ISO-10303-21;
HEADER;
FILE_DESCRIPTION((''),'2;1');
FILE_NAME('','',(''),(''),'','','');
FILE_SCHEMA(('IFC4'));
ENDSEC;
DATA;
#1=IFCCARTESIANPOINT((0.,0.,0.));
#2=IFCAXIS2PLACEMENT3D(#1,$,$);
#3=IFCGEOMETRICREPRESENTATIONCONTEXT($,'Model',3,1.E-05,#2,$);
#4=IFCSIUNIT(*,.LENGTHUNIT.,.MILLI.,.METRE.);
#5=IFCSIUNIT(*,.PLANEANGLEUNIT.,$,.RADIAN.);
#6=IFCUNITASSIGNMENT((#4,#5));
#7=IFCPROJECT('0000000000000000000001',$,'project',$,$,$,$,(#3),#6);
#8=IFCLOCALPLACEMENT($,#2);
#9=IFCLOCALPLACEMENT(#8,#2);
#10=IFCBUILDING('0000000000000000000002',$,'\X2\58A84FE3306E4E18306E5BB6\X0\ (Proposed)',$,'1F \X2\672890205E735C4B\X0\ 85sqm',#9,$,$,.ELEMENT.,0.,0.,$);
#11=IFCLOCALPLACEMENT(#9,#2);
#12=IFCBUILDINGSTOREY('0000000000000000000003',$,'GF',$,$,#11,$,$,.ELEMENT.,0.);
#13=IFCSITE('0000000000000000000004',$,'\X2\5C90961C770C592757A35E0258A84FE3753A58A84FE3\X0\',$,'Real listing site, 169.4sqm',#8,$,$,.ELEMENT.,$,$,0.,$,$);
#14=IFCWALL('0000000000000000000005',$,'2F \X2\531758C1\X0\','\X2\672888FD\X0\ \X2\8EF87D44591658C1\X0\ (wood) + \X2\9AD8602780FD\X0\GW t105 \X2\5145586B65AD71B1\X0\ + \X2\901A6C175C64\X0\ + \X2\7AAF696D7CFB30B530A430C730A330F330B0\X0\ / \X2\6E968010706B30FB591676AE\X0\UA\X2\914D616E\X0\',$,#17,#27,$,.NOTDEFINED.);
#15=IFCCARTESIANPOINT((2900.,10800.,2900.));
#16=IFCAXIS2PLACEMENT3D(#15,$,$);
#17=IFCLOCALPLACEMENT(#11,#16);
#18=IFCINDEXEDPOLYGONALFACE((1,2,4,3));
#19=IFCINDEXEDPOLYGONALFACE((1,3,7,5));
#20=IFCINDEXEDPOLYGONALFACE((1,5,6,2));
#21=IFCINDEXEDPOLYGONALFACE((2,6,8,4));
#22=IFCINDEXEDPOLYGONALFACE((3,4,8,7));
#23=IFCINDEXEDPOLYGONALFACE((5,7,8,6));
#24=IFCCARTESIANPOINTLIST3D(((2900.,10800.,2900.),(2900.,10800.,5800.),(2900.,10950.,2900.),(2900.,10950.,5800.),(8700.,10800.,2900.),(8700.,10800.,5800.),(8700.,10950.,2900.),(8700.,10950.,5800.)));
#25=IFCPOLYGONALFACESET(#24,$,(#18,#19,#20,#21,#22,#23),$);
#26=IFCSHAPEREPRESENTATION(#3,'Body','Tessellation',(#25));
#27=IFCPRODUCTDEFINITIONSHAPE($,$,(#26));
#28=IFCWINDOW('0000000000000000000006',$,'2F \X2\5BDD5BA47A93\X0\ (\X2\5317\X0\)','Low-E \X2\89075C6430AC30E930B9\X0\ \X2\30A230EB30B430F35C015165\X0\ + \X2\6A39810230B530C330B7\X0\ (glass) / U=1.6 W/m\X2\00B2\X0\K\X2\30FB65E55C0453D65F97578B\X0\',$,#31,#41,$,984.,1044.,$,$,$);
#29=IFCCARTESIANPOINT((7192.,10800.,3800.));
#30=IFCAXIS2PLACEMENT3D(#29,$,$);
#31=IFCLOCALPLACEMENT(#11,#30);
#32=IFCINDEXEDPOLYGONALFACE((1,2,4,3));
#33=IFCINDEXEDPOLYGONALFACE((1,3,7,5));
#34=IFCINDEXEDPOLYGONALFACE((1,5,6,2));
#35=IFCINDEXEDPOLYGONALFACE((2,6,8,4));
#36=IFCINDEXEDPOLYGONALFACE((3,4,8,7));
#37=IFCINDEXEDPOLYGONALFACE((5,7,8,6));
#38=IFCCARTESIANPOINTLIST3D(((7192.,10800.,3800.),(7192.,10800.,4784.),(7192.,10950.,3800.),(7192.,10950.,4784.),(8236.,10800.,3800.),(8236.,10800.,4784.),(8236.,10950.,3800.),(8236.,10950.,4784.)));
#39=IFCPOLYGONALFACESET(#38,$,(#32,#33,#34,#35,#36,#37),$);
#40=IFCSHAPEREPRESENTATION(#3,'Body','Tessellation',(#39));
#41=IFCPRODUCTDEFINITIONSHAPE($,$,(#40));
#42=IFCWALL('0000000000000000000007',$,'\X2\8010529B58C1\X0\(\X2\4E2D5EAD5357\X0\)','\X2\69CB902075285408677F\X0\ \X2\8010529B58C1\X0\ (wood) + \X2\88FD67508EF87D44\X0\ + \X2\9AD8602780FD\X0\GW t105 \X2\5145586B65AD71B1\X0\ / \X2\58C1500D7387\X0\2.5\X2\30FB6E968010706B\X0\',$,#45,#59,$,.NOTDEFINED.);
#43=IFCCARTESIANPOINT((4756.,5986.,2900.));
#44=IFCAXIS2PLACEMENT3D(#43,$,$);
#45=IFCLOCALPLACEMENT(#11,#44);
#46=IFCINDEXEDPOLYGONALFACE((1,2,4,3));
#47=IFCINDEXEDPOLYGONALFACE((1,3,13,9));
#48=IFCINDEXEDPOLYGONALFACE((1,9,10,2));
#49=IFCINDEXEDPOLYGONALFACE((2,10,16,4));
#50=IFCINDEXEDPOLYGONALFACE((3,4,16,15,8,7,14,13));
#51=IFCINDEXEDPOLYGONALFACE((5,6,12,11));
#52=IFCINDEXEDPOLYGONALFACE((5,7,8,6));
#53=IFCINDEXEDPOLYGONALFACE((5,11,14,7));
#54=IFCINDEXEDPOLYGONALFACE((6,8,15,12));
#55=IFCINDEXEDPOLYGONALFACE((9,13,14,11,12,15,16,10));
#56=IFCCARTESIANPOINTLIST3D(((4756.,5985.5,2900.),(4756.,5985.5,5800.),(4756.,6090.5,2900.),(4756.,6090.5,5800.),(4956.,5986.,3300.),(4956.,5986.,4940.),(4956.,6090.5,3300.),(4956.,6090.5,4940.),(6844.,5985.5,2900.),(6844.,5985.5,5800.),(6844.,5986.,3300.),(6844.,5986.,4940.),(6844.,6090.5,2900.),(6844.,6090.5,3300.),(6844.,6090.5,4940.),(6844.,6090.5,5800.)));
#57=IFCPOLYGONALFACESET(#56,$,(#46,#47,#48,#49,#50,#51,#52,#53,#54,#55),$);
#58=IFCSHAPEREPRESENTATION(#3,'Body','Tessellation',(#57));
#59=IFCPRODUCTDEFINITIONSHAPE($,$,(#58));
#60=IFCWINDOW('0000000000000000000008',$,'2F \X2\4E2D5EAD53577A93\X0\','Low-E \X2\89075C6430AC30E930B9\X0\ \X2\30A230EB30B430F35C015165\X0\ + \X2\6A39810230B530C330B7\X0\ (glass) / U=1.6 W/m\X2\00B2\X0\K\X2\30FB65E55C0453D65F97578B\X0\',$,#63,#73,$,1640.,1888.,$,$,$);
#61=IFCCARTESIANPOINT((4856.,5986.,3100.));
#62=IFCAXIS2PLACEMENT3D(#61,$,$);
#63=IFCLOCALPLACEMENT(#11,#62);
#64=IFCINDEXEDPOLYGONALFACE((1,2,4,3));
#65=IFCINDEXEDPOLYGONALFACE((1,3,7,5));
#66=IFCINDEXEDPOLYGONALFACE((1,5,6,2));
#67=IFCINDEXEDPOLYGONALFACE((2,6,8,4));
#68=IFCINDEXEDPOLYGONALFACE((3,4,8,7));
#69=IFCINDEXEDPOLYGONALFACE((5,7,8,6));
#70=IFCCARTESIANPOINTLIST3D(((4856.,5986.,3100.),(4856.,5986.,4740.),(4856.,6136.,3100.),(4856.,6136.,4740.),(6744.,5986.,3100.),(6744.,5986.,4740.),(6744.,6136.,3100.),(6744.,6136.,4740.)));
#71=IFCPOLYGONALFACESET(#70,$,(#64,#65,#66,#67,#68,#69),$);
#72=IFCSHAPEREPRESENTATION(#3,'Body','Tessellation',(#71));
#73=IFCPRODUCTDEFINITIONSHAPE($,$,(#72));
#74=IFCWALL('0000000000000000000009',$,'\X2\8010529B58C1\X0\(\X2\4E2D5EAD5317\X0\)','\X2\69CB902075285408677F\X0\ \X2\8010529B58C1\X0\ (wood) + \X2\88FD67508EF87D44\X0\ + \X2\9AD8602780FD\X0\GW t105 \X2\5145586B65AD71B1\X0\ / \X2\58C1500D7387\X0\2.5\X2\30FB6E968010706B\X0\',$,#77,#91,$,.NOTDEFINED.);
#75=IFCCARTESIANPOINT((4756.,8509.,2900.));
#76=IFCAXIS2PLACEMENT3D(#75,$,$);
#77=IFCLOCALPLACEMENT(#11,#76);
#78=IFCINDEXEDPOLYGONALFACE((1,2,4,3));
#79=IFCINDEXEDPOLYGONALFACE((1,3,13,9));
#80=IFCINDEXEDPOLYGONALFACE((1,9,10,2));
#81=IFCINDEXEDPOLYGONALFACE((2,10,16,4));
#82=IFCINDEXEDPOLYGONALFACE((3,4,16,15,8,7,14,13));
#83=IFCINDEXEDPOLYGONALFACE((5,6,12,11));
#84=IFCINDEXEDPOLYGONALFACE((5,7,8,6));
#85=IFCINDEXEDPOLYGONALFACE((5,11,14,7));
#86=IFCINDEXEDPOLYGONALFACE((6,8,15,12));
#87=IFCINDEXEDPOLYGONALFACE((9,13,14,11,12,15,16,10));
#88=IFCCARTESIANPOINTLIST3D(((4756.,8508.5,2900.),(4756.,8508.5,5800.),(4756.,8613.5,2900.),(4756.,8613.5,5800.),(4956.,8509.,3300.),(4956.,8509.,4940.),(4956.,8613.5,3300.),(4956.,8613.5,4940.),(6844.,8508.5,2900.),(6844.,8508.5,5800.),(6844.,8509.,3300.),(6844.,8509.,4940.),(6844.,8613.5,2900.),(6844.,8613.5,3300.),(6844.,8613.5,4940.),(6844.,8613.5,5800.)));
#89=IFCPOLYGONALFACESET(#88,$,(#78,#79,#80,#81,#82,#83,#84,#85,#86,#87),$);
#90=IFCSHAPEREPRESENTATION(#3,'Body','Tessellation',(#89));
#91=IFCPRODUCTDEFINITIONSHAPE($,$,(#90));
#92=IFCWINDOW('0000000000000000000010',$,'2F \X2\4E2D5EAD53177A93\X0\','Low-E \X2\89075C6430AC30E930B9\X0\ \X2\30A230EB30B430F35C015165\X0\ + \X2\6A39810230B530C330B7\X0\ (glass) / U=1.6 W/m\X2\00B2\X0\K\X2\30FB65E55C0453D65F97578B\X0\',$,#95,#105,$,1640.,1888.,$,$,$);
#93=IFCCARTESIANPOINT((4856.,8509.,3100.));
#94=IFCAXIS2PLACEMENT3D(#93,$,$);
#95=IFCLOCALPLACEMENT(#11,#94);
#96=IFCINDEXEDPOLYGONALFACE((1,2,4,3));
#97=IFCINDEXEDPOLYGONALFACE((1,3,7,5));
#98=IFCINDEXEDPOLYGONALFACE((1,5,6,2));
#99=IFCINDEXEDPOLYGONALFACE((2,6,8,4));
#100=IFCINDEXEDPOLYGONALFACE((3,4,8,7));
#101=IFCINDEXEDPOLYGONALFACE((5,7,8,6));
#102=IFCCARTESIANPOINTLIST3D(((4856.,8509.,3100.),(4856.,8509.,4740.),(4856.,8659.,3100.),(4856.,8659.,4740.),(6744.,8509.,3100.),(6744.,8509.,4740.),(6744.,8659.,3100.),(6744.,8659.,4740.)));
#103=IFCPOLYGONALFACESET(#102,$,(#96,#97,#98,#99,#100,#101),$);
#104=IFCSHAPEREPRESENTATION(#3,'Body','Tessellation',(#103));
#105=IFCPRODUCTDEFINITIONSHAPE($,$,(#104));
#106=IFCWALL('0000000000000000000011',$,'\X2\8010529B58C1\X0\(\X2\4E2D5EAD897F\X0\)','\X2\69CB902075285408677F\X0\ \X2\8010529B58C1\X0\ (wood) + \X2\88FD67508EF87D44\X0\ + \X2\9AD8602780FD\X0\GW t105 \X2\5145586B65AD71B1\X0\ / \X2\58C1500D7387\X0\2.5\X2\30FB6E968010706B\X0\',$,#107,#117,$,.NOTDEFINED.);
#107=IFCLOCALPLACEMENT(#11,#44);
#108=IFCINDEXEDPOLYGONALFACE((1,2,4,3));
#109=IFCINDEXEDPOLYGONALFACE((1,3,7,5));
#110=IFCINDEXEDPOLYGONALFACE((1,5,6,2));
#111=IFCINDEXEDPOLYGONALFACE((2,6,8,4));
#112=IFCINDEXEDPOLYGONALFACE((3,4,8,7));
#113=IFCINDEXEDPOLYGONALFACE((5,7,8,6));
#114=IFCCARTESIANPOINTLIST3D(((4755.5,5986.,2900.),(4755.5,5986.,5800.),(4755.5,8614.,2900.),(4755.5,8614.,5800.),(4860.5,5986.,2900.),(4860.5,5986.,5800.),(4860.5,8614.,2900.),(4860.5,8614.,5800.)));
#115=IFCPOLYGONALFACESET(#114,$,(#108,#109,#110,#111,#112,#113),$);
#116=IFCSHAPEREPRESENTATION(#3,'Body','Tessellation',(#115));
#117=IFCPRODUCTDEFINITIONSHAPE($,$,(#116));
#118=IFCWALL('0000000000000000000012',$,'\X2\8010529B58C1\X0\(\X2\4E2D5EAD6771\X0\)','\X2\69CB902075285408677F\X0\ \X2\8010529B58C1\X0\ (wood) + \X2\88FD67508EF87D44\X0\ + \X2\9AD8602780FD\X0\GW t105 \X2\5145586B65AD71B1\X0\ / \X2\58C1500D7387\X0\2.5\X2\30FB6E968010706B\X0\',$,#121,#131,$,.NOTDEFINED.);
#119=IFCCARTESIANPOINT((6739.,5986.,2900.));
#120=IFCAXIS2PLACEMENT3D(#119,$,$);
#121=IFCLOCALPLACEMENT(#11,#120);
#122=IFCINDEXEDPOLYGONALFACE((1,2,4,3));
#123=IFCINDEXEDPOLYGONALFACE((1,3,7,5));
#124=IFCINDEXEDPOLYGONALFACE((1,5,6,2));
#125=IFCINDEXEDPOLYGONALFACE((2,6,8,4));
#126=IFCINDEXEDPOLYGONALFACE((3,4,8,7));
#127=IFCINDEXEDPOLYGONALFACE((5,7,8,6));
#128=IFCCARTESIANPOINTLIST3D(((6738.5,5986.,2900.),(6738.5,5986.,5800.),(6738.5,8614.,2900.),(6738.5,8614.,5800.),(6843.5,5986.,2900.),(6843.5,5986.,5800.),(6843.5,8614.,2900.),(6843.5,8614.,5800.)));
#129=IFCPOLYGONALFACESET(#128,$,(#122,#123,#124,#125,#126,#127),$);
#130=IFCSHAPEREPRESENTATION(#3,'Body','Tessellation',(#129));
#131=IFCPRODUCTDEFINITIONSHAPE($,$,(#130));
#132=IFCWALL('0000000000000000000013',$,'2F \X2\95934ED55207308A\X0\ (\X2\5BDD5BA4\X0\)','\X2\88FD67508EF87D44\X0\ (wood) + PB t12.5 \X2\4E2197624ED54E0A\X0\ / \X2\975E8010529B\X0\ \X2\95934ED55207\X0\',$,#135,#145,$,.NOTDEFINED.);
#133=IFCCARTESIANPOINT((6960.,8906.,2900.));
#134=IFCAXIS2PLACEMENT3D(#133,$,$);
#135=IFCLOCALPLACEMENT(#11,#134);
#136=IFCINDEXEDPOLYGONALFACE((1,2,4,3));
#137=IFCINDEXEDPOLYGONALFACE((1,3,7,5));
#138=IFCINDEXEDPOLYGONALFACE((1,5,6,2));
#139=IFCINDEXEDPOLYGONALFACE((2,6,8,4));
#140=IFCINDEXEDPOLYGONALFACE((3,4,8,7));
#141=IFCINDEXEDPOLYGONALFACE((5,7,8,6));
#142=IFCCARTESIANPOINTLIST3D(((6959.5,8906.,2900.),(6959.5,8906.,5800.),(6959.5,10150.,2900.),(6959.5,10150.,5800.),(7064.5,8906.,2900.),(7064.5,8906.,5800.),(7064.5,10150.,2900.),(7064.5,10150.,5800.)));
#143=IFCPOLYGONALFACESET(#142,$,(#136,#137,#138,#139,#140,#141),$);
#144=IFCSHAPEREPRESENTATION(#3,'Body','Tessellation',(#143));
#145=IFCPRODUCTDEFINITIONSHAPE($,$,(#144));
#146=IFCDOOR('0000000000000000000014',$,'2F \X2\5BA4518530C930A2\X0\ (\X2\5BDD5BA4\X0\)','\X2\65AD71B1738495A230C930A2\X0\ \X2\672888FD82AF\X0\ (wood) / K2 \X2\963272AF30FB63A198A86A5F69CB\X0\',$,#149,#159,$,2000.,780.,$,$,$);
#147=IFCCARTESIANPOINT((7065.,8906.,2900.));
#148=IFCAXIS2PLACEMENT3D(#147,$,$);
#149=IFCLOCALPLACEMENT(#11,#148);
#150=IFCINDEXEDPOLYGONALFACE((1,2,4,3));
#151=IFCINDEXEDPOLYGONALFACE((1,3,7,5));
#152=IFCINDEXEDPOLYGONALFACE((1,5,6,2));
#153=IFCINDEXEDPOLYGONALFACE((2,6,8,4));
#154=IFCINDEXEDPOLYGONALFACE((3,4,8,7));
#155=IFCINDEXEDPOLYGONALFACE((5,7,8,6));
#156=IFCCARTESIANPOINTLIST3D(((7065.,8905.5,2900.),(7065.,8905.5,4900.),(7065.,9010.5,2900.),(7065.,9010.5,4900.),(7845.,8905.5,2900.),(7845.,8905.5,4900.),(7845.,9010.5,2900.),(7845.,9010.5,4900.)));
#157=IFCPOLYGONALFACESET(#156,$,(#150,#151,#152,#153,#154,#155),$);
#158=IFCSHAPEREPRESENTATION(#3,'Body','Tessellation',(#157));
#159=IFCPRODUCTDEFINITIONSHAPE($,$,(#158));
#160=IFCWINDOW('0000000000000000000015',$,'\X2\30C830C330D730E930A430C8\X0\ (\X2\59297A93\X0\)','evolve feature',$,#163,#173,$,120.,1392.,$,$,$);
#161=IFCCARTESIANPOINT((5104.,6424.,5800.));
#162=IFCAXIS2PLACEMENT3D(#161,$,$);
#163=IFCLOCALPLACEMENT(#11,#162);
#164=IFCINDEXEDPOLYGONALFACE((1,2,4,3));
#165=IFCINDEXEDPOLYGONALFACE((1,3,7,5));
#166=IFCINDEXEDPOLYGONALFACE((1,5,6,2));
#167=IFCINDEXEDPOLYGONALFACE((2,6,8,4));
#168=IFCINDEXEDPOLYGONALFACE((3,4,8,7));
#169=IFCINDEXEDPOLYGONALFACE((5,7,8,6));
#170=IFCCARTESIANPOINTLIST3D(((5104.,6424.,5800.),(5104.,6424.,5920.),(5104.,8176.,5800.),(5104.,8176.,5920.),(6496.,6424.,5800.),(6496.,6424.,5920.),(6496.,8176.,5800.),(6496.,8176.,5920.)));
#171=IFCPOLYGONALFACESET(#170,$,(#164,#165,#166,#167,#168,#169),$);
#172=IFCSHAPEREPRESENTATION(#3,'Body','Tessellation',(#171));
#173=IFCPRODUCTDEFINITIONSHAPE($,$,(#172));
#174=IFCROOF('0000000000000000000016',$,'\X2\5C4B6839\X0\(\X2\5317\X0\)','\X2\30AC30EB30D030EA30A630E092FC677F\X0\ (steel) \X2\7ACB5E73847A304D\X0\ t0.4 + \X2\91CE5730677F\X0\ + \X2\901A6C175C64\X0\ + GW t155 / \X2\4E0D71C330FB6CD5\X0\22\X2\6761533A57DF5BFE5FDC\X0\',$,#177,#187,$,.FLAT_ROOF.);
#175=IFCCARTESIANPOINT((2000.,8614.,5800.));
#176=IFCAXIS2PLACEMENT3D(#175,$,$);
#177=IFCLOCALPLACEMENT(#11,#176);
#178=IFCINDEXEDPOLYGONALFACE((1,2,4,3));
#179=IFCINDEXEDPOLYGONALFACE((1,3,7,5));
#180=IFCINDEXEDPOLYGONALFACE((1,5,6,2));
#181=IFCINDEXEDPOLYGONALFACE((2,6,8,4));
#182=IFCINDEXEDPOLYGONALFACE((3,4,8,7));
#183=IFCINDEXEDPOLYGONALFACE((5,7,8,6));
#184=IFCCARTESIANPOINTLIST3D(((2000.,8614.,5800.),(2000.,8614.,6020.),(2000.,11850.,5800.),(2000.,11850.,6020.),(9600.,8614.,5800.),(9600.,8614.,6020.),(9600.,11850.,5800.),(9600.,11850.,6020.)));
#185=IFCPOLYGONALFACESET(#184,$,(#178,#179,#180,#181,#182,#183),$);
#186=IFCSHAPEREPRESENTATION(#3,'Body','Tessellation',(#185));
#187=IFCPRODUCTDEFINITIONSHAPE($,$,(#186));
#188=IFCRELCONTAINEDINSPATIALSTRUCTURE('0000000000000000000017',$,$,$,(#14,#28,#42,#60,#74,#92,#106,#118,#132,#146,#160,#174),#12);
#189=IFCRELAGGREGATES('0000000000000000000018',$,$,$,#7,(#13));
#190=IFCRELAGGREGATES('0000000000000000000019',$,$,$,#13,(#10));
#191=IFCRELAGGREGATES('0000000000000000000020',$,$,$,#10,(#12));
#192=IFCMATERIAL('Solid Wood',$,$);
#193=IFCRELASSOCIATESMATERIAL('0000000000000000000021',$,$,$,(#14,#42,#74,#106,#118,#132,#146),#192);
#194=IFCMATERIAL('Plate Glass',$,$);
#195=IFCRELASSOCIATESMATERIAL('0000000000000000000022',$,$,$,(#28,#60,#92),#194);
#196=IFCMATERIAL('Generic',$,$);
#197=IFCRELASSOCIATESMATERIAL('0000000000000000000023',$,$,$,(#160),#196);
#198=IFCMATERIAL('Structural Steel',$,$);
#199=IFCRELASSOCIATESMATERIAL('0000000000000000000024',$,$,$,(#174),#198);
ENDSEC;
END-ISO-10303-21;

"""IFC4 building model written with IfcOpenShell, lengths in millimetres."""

from ifc_helpers import new_model, si_unit, frame, frame_2d, origin, place, context, project, spatial, rectangle, extrude, material, element, fill, save


model = new_model("IFC4")

# Units and contexts
model_context = context("Model", 3, precision=1e-05, world=origin())
ifc_project = project(units=[si_unit("LENGTHUNIT", "METRE", prefix="MILLI"), si_unit("PLANEANGLEUNIT", "RADIAN")], contexts=[model_context])

# Site, building, storey
site_placement = place(None, origin())
site = spatial("IfcSite", under=ifc_project, at=site_placement, Name="岐阜県大垣市墨俣町墨俣", ObjectType="Real listing site, 169.4sqm", CompositionType="ELEMENT", RefElevation=0.0)
building_placement = place(site_placement, origin())
building = spatial("IfcBuilding", under=site, at=building_placement, Name="墨俣の丘の家 (Proposed)", ObjectType="1F 木造平屋 85sqm", CompositionType="ELEMENT", ElevationOfRefHeight=0.0, ElevationOfTerrain=0.0)
storey_placement = place(building_placement, origin())
storey = spatial("IfcBuildingStorey", under=building, at=storey_placement, Name="GF", CompositionType="ELEMENT", Elevation=0.0)

# Shared definitions
ifc_material_1 = material(Name="Solid Wood")

# Walls, openings, windows
wall_1_placement = place(storey_placement, frame((2900.0, 10800.0, 2900.0)))
wall_1 = element("IfcWall", 1, at=wall_1_placement, inside=storey, material=ifc_material_1, Name="2F 北壁", Description="木製 軸組外壁 (wood) + 高性能GW t105 充填断熱 + 通気層 + 窯業系サイディング / 準耐火・外皮UA配慮", PredefinedType="NOTDEFINED", context=model_context, shape_type="SweptSolid", body=[
    extrude(rectangle(XDim=5800.0, YDim=150.0, at=frame_2d((2900.0, 75.0))), frame((2900.0, 10800.0, 2900.0)), (0.0, 0.0, 1.0), 2900.0),
])
opening_1_placement = place(storey_placement, frame((7192.0, 10800.0, 3800.0)))
opening_1 = element("IfcOpeningElement", 2, at=opening_1_placement, cuts=wall_1, PredefinedType="NOTDEFINED", context=model_context, shape_type="SweptSolid", body=[
    extrude(rectangle(XDim=1044.0, YDim=150.0, at=frame_2d((522.0, 75.0))), frame((7192.0, 10800.0, 3800.0)), (0.0, 0.0, 1.0), 984.0),
])
ifc_material_2 = material(Name="Plate Glass")
window_1_placement = place(storey_placement, frame((7192.0, 10800.0, 3800.0)))
window_1 = element("IfcWindow", 3, at=window_1_placement, inside=storey, material=ifc_material_2, Name="2F 寝室窓 (北)", Description="Low-E 複層ガラス アルゴン封入 + 樹脂サッシ (glass) / U=1.6 W/m²K・日射取得型", OverallHeight=984.0, OverallWidth=1044.0, context=model_context, shape_type="SweptSolid", body=[
    extrude(rectangle(XDim=1044.0, YDim=150.0, at=frame_2d((522.0, 75.0))), frame((7192.0, 10800.0, 3800.0)), (0.0, 0.0, 1.0), 984.0),
])
fill(opening_1, window_1)
wall_2_placement = place(storey_placement, frame((4756.0, 5986.0, 2900.0)))
wall_2 = element("IfcWall", 4, at=wall_2_placement, inside=storey, material=ifc_material_1, Name="耐力壁(中庭南)", Description="構造用合板 耐力壁 (wood) + 製材軸組 + 高性能GW t105 充填断熱 / 壁倍率2.5・準耐火", PredefinedType="NOTDEFINED", context=model_context, shape_type="SweptSolid", body=[
    extrude(rectangle(XDim=2088.0, YDim=105.0, at=frame_2d((1044.0, 52.0))), frame((4756.0, 5986.0, 2900.0)), (0.0, 0.0, 1.0), 2900.0),
])
opening_2_placement = place(storey_placement, frame((4856.0, 5986.0, 3100.0)))
opening_2 = element("IfcOpeningElement", 5, at=opening_2_placement, cuts=wall_2, PredefinedType="NOTDEFINED", context=model_context, shape_type="SweptSolid", body=[
    extrude(rectangle(XDim=1888.0, YDim=150.0, at=frame_2d((944.0, 75.0))), frame((4856.0, 5986.0, 3100.0)), (0.0, 0.0, 1.0), 1640.0),
])
window_2_placement = place(storey_placement, frame((4856.0, 5986.0, 3100.0)))
window_2 = element("IfcWindow", 6, at=window_2_placement, inside=storey, material=ifc_material_2, Name="2F 中庭南窓", Description="Low-E 複層ガラス アルゴン封入 + 樹脂サッシ (glass) / U=1.6 W/m²K・日射取得型", OverallHeight=1640.0, OverallWidth=1888.0, context=model_context, shape_type="SweptSolid", body=[
    extrude(rectangle(XDim=1888.0, YDim=150.0, at=frame_2d((944.0, 75.0))), frame((4856.0, 5986.0, 3100.0)), (0.0, 0.0, 1.0), 1640.0),
])
fill(opening_2, window_2)
wall_3_placement = place(storey_placement, frame((4756.0, 8509.0, 2900.0)))
wall_3 = element("IfcWall", 7, at=wall_3_placement, inside=storey, material=ifc_material_1, Name="耐力壁(中庭北)", Description="構造用合板 耐力壁 (wood) + 製材軸組 + 高性能GW t105 充填断熱 / 壁倍率2.5・準耐火", PredefinedType="NOTDEFINED", context=model_context, shape_type="SweptSolid", body=[
    extrude(rectangle(XDim=2088.0, YDim=105.0, at=frame_2d((1044.0, 52.0))), frame((4756.0, 8509.0, 2900.0)), (0.0, 0.0, 1.0), 2900.0),
])
opening_3_placement = place(storey_placement, frame((4856.0, 8509.0, 3100.0)))
opening_3 = element("IfcOpeningElement", 8, at=opening_3_placement, cuts=wall_3, PredefinedType="NOTDEFINED", context=model_context, shape_type="SweptSolid", body=[
    extrude(rectangle(XDim=1888.0, YDim=150.0, at=frame_2d((944.0, 75.0))), frame((4856.0, 8509.0, 3100.0)), (0.0, 0.0, 1.0), 1640.0),
])
window_3_placement = place(storey_placement, frame((4856.0, 8509.0, 3100.0)))
window_3 = element("IfcWindow", 9, at=window_3_placement, inside=storey, material=ifc_material_2, Name="2F 中庭北窓", Description="Low-E 複層ガラス アルゴン封入 + 樹脂サッシ (glass) / U=1.6 W/m²K・日射取得型", OverallHeight=1640.0, OverallWidth=1888.0, context=model_context, shape_type="SweptSolid", body=[
    extrude(rectangle(XDim=1888.0, YDim=150.0, at=frame_2d((944.0, 75.0))), frame((4856.0, 8509.0, 3100.0)), (0.0, 0.0, 1.0), 1640.0),
])
fill(opening_3, window_3)

# Walls
wall_4_placement = place(storey_placement, frame((4756.0, 5986.0, 2900.0)))
element("IfcWall", 10, at=wall_4_placement, inside=storey, material=ifc_material_1, Name="耐力壁(中庭西)", Description="構造用合板 耐力壁 (wood) + 製材軸組 + 高性能GW t105 充填断熱 / 壁倍率2.5・準耐火", PredefinedType="NOTDEFINED", context=model_context, shape_type="SweptSolid", body=[
    extrude(rectangle(XDim=105.0, YDim=2628.0, at=frame_2d((52.0, 1314.0))), frame((4756.0, 5986.0, 2900.0)), (0.0, 0.0, 1.0), 2900.0),
])
wall_5_placement = place(storey_placement, frame((6739.0, 5986.0, 2900.0)))
element("IfcWall", 11, at=wall_5_placement, inside=storey, material=ifc_material_1, Name="耐力壁(中庭東)", Description="構造用合板 耐力壁 (wood) + 製材軸組 + 高性能GW t105 充填断熱 / 壁倍率2.5・準耐火", PredefinedType="NOTDEFINED", context=model_context, shape_type="SweptSolid", body=[
    extrude(rectangle(XDim=105.0, YDim=2628.0, at=frame_2d((52.0, 1314.0))), frame((6739.0, 5986.0, 2900.0)), (0.0, 0.0, 1.0), 2900.0),
])
wall_6_placement = place(storey_placement, frame((6960.0, 8906.0, 2900.0)))
element("IfcWall", 12, at=wall_6_placement, inside=storey, material=ifc_material_1, Name="2F 間仕切り (寝室)", Description="製材軸組 (wood) + PB t12.5 両面仕上 / 非耐力 間仕切", PredefinedType="NOTDEFINED", context=model_context, shape_type="SweptSolid", body=[
    extrude(rectangle(XDim=105.0, YDim=1244.0, at=frame_2d((52.0, 622.0))), frame((6960.0, 8906.0, 2900.0)), (0.0, 0.0, 1.0), 2900.0),
])

# Door
door_placement = place(storey_placement, frame((7065.0, 8906.0, 2900.0)))
element("IfcDoor", 13, at=door_placement, inside=storey, material=ifc_material_1, Name="2F 室内ドア (寝室)", Description="断熱玄関ドア 木製芯 (wood) / K2 防犯・採風機構", OverallHeight=2000.0, OverallWidth=780.0, context=model_context, shape_type="SweptSolid", body=[
    extrude(rectangle(XDim=780.0, YDim=105.0, at=frame_2d((390.0, 52.0))), frame((7065.0, 8906.0, 2900.0)), (0.0, 0.0, 1.0), 2000.0),
])

# Window
ifc_material_3 = material(Name="Generic")
window_4_placement = place(storey_placement, frame((5104.0, 6424.0, 5800.0)))
element("IfcWindow", 14, at=window_4_placement, inside=storey, material=ifc_material_3, Name="トップライト (天窓)", Description="evolve feature", OverallHeight=120.0, OverallWidth=1392.0, context=model_context, shape_type="SweptSolid", body=[
    extrude(rectangle(XDim=1392.0, YDim=1752.0, at=frame_2d((696.0, 876.0))), frame((5104.0, 6424.0, 5800.0)), (0.0, 0.0, 1.0), 120.0),
])

# Roof
ifc_material_4 = material(Name="Structural Steel")
for number, where, name in (
    (15, (2000.0, 8614.0, 5800.0), "屋根(北)"),
):
    element("IfcRoof", number, at=place(storey_placement, frame(where)), inside=storey, material=ifc_material_4, Name=name, Description="ガルバリウム鋼板 (steel) 立平葺き t0.4 + 野地板 + 通気層 + GW t155 / 不燃・法22条区域対応", PredefinedType="FLAT_ROOF", context=model_context, shape_type="SweptSolid", body=[
        extrude(rectangle(XDim=7600.0, YDim=3236.0, at=frame_2d((3800.0, 1618.0))), frame((2000.0, 8614.0, 5800.0)), (0.0, 0.0, 1.0), 220.0),
    ])

save(model, "model.ifc")
